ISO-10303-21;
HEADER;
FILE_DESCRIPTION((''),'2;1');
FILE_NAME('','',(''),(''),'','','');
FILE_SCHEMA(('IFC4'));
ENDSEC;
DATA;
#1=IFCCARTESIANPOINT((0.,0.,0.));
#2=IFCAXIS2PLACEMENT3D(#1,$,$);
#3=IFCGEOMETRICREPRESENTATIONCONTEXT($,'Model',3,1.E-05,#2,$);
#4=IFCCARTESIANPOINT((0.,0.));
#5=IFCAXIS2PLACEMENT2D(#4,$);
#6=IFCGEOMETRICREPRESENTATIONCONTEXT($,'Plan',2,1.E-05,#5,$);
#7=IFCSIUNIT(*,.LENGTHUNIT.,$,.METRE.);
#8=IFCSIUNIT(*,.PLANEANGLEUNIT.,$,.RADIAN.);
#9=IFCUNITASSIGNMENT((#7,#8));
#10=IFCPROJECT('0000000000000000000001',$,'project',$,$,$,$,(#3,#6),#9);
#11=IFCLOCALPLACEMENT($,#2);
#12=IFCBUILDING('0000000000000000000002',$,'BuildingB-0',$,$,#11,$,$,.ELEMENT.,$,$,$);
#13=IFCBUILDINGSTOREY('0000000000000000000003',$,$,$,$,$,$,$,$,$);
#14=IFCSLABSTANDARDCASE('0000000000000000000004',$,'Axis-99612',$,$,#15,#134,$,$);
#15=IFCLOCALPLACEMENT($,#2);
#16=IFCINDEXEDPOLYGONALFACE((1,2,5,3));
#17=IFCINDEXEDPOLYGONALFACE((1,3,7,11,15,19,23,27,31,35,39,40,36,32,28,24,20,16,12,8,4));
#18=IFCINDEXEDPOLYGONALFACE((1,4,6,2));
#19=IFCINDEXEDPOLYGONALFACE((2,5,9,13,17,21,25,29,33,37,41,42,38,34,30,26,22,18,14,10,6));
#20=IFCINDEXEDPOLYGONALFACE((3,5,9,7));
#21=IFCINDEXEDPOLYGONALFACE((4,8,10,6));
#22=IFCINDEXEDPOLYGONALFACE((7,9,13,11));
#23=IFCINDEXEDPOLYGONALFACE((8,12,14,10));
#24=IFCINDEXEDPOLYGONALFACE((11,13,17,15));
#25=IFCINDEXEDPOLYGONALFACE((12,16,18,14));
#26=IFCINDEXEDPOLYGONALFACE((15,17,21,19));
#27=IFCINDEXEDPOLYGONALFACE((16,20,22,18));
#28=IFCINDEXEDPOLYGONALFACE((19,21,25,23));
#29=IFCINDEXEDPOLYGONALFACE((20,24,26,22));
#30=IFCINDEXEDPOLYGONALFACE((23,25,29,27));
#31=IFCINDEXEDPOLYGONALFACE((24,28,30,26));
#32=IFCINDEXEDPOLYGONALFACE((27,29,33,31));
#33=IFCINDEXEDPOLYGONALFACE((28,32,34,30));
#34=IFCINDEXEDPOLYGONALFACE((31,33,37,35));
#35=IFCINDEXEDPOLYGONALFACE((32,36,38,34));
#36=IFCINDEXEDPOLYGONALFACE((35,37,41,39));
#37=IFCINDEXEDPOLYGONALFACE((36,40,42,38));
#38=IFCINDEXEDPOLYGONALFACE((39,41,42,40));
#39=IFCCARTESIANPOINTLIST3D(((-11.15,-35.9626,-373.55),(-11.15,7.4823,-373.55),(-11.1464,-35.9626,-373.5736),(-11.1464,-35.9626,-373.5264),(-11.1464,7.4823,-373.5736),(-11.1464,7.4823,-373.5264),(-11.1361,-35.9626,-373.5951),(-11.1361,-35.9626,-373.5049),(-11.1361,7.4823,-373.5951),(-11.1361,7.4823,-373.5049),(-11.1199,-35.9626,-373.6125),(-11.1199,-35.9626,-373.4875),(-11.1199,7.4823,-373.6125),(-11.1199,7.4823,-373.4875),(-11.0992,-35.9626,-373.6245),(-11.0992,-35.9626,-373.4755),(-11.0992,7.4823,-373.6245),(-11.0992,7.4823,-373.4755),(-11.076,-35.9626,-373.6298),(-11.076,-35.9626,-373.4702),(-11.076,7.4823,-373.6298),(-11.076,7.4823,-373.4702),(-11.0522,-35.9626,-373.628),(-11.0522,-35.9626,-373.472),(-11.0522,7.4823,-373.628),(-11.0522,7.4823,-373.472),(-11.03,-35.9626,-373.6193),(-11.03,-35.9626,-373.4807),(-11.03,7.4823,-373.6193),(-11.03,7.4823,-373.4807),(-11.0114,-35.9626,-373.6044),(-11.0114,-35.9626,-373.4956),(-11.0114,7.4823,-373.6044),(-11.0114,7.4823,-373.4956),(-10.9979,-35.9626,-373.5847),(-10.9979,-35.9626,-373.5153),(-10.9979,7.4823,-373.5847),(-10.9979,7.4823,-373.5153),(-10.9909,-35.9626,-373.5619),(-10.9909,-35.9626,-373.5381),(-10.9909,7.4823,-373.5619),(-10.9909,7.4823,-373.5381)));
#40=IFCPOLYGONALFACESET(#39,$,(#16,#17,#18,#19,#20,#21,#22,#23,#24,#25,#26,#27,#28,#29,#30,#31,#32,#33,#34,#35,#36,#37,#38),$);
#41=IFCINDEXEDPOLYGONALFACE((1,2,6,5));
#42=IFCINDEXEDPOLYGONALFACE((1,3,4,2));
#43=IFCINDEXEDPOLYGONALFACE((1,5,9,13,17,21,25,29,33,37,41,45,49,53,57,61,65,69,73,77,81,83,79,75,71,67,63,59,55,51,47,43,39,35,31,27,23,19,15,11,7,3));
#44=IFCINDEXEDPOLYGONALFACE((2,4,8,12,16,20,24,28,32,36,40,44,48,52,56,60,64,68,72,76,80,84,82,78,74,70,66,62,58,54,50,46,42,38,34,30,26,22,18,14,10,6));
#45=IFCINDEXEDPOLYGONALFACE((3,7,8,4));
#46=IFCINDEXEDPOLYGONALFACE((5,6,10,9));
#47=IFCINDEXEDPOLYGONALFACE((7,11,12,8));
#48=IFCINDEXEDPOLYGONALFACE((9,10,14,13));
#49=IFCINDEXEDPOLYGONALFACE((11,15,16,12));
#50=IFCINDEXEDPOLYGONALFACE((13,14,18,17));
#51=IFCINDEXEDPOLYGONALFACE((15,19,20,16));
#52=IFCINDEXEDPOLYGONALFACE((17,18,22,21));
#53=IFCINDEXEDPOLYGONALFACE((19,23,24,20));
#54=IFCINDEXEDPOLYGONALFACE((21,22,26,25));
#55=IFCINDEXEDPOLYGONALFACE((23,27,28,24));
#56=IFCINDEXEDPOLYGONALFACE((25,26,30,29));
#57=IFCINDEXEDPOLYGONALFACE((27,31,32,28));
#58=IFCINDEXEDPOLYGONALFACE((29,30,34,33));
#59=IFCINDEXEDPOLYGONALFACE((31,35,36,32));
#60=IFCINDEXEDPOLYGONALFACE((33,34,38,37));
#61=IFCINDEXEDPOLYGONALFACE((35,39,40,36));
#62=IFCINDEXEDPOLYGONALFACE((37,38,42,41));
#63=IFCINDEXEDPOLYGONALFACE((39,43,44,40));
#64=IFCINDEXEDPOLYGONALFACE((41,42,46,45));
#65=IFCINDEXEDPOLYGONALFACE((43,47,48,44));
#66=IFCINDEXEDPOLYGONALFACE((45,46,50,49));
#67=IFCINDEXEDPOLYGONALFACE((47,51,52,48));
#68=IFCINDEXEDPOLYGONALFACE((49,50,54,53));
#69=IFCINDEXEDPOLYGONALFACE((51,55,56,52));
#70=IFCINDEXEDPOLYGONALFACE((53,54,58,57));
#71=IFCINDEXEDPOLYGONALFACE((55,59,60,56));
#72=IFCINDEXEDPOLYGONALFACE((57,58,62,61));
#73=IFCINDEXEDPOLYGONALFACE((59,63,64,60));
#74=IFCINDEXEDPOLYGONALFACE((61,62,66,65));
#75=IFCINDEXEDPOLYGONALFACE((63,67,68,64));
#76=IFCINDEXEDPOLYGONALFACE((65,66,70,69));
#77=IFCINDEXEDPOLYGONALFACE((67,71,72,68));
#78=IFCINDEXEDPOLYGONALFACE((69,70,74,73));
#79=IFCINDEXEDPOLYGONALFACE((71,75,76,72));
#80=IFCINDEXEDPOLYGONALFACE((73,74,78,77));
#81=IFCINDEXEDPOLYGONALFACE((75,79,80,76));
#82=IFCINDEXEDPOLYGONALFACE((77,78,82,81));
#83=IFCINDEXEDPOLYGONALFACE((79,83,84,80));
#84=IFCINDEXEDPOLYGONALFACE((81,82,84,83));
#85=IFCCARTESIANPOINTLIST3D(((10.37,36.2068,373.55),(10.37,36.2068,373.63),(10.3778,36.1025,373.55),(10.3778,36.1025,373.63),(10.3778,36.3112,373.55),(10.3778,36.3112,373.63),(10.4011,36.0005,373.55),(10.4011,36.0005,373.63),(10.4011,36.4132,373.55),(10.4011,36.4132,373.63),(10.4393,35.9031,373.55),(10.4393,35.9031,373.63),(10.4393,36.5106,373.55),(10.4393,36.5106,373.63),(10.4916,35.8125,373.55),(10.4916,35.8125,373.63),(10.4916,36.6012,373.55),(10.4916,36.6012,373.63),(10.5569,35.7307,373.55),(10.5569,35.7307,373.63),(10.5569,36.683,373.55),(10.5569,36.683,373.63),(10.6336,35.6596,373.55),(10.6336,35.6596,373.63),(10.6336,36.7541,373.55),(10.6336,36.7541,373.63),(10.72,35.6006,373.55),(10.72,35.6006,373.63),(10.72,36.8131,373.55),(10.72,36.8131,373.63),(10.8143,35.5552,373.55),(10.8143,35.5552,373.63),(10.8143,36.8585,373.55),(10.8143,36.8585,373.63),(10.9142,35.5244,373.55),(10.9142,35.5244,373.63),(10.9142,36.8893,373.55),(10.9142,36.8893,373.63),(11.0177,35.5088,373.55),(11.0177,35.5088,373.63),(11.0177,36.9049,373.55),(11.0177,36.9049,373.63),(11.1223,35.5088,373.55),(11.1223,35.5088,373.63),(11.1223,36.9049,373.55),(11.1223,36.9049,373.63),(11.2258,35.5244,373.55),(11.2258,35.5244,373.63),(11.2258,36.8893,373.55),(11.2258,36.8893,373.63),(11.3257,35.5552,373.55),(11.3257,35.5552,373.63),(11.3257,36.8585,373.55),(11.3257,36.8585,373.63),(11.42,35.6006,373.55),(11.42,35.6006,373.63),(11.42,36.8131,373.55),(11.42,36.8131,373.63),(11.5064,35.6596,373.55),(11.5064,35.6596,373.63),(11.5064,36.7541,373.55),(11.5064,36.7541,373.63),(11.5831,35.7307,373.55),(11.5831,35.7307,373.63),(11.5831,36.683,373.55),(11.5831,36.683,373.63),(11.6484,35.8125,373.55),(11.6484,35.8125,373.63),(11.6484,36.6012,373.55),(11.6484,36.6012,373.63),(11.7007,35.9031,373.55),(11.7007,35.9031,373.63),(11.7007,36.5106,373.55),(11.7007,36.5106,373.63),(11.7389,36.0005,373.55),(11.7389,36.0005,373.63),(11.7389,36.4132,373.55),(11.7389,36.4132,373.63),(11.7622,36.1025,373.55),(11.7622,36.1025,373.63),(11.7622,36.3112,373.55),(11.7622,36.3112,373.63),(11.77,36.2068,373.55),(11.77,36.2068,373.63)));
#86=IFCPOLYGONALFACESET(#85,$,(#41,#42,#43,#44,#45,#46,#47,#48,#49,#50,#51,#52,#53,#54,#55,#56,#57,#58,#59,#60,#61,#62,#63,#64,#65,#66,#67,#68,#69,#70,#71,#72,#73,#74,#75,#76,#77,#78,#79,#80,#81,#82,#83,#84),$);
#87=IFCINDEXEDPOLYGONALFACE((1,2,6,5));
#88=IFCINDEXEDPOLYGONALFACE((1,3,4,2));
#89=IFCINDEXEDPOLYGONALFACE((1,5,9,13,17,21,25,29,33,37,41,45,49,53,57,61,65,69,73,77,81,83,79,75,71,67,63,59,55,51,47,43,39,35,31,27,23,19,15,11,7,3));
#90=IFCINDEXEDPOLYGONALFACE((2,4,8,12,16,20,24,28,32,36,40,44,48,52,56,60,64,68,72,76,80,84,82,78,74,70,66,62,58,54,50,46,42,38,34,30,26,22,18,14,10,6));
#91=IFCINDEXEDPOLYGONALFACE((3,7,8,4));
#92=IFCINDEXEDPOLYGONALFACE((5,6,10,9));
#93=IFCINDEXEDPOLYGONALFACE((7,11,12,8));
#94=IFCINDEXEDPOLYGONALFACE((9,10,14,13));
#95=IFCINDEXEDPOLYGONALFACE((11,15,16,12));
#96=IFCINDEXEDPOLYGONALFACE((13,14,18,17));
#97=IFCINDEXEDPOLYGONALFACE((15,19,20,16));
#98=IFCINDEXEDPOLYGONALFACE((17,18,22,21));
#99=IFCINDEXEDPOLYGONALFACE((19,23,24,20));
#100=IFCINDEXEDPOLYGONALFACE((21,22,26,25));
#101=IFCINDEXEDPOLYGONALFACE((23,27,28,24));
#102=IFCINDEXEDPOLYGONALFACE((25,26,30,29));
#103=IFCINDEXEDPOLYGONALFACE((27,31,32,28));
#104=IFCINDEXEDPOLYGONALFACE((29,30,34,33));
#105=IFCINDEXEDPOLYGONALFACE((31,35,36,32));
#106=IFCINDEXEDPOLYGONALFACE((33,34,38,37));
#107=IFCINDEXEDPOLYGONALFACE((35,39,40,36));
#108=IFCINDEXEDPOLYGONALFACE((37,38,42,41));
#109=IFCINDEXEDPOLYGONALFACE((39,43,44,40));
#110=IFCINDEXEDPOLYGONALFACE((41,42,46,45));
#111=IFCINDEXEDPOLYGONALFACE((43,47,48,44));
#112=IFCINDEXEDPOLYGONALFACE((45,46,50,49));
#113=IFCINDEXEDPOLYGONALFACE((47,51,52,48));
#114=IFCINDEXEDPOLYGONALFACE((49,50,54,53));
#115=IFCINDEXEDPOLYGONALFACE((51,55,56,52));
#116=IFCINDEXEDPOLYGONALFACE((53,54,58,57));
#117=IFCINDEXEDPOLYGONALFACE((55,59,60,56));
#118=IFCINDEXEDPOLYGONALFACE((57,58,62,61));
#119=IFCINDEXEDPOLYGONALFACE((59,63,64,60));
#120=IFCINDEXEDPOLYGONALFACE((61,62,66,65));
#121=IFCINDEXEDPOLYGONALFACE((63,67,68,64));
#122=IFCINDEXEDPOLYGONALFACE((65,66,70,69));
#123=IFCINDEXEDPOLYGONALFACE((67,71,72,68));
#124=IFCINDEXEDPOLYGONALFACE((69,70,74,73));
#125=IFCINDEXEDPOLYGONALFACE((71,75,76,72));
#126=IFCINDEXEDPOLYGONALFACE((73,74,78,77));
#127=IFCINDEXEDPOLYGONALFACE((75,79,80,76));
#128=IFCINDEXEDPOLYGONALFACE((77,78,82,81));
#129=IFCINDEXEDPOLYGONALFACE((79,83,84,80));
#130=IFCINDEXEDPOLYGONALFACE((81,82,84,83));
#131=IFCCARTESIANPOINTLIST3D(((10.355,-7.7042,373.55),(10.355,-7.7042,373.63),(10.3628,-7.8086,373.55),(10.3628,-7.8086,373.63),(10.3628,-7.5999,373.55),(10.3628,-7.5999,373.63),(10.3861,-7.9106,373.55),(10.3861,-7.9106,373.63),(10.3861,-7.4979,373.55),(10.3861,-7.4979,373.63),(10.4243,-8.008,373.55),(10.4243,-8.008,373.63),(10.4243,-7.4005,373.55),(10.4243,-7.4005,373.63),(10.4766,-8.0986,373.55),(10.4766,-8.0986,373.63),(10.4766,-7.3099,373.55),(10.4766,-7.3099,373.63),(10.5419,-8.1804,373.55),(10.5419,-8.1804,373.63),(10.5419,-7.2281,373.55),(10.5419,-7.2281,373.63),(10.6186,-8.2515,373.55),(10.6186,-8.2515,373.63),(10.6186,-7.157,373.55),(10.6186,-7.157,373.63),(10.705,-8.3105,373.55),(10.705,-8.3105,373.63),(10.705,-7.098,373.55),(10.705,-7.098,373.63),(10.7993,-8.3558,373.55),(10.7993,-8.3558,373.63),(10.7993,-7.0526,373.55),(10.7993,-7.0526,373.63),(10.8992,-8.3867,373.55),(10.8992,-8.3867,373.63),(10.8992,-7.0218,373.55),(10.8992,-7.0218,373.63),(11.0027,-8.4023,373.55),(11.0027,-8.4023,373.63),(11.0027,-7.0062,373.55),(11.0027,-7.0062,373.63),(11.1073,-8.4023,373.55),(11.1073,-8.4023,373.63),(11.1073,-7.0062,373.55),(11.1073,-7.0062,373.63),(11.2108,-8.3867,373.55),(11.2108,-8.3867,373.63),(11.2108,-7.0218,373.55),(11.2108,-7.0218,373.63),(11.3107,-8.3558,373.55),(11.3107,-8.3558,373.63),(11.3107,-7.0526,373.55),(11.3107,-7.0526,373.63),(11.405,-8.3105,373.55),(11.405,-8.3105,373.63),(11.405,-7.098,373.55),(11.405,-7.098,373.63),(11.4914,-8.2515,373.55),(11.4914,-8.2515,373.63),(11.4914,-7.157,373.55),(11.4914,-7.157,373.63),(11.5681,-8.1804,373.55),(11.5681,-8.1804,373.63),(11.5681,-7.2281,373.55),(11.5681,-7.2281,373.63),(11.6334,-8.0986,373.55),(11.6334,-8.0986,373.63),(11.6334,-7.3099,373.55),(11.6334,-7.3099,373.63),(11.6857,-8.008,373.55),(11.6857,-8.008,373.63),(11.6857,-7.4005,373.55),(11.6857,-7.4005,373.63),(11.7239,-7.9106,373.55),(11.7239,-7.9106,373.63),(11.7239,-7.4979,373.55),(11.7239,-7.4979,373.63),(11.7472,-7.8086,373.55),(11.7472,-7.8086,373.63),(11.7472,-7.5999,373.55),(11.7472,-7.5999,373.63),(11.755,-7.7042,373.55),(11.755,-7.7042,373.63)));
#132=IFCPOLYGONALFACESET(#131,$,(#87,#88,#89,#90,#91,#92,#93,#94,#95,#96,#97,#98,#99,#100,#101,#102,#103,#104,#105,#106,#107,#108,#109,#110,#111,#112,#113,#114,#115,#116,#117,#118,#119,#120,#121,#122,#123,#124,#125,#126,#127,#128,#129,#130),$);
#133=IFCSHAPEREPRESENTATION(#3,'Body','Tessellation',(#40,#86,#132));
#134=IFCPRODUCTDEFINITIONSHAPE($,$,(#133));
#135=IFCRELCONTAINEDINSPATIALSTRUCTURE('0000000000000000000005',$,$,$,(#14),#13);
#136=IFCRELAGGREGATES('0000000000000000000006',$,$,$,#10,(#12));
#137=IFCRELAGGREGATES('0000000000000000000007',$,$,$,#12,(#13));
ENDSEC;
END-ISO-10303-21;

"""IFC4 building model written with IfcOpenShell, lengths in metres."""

from ifc_helpers import new_model, entity, si_unit, frame, origin, origin_2d, place, context, project, spatial, circle, extrude, element, save


model = new_model("IFC4")

# Units and contexts
model_context = context("Model", 3, precision=1e-05, world=origin())
plan_context = context("Plan", 2, precision=1e-05, world=origin_2d())
ifc_project = project(units=[si_unit("LENGTHUNIT", "METRE"), si_unit("PLANEANGLEUNIT", "RADIAN")], contexts=[model_context, plan_context])

# Building, storey
building_placement = place(None, origin())
building = spatial("IfcBuilding", under=ifc_project, at=building_placement, Name="BuildingB-0", CompositionType="ELEMENT")
storey = spatial("IfcBuildingStorey", under=building)

# Slab
element("IfcSlabStandardCase", 1, inside=storey, Name="Axis-99612", context=model_context, shape_type="AdvancedSweptSolid", body=[
    entity("IfcSurfaceCurveSweptAreaSolid", entity("IfcCircleProfileDef", "AREA", None, None, 0.08), None, entity("IfcPolyline", [entity("IfcCartesianPoint", [11.07, 35.9626, 373.55]), entity("IfcCartesianPoint", [11.07, -7.4823, 373.55])]), None, None, entity("IfcPlane", entity("IfcAxis2Placement3D", entity("IfcCartesianPoint", [11.07, 35.9626, 373.55]), entity("IfcDirection", [0.0, 0.0, 1.0]), entity("IfcDirection", [1.0, 0.0, 0.0])))),
    extrude(circle(Radius=0.7), frame((11.07, 36.2068, 373.55)), (0.0, 0.0, 1.0), 0.08),
    extrude(circle(Radius=0.7), frame((11.055, -7.7042, 373.55)), (0.0, 0.0, 1.0), 0.08),
])

save(model, "model.ifc")
